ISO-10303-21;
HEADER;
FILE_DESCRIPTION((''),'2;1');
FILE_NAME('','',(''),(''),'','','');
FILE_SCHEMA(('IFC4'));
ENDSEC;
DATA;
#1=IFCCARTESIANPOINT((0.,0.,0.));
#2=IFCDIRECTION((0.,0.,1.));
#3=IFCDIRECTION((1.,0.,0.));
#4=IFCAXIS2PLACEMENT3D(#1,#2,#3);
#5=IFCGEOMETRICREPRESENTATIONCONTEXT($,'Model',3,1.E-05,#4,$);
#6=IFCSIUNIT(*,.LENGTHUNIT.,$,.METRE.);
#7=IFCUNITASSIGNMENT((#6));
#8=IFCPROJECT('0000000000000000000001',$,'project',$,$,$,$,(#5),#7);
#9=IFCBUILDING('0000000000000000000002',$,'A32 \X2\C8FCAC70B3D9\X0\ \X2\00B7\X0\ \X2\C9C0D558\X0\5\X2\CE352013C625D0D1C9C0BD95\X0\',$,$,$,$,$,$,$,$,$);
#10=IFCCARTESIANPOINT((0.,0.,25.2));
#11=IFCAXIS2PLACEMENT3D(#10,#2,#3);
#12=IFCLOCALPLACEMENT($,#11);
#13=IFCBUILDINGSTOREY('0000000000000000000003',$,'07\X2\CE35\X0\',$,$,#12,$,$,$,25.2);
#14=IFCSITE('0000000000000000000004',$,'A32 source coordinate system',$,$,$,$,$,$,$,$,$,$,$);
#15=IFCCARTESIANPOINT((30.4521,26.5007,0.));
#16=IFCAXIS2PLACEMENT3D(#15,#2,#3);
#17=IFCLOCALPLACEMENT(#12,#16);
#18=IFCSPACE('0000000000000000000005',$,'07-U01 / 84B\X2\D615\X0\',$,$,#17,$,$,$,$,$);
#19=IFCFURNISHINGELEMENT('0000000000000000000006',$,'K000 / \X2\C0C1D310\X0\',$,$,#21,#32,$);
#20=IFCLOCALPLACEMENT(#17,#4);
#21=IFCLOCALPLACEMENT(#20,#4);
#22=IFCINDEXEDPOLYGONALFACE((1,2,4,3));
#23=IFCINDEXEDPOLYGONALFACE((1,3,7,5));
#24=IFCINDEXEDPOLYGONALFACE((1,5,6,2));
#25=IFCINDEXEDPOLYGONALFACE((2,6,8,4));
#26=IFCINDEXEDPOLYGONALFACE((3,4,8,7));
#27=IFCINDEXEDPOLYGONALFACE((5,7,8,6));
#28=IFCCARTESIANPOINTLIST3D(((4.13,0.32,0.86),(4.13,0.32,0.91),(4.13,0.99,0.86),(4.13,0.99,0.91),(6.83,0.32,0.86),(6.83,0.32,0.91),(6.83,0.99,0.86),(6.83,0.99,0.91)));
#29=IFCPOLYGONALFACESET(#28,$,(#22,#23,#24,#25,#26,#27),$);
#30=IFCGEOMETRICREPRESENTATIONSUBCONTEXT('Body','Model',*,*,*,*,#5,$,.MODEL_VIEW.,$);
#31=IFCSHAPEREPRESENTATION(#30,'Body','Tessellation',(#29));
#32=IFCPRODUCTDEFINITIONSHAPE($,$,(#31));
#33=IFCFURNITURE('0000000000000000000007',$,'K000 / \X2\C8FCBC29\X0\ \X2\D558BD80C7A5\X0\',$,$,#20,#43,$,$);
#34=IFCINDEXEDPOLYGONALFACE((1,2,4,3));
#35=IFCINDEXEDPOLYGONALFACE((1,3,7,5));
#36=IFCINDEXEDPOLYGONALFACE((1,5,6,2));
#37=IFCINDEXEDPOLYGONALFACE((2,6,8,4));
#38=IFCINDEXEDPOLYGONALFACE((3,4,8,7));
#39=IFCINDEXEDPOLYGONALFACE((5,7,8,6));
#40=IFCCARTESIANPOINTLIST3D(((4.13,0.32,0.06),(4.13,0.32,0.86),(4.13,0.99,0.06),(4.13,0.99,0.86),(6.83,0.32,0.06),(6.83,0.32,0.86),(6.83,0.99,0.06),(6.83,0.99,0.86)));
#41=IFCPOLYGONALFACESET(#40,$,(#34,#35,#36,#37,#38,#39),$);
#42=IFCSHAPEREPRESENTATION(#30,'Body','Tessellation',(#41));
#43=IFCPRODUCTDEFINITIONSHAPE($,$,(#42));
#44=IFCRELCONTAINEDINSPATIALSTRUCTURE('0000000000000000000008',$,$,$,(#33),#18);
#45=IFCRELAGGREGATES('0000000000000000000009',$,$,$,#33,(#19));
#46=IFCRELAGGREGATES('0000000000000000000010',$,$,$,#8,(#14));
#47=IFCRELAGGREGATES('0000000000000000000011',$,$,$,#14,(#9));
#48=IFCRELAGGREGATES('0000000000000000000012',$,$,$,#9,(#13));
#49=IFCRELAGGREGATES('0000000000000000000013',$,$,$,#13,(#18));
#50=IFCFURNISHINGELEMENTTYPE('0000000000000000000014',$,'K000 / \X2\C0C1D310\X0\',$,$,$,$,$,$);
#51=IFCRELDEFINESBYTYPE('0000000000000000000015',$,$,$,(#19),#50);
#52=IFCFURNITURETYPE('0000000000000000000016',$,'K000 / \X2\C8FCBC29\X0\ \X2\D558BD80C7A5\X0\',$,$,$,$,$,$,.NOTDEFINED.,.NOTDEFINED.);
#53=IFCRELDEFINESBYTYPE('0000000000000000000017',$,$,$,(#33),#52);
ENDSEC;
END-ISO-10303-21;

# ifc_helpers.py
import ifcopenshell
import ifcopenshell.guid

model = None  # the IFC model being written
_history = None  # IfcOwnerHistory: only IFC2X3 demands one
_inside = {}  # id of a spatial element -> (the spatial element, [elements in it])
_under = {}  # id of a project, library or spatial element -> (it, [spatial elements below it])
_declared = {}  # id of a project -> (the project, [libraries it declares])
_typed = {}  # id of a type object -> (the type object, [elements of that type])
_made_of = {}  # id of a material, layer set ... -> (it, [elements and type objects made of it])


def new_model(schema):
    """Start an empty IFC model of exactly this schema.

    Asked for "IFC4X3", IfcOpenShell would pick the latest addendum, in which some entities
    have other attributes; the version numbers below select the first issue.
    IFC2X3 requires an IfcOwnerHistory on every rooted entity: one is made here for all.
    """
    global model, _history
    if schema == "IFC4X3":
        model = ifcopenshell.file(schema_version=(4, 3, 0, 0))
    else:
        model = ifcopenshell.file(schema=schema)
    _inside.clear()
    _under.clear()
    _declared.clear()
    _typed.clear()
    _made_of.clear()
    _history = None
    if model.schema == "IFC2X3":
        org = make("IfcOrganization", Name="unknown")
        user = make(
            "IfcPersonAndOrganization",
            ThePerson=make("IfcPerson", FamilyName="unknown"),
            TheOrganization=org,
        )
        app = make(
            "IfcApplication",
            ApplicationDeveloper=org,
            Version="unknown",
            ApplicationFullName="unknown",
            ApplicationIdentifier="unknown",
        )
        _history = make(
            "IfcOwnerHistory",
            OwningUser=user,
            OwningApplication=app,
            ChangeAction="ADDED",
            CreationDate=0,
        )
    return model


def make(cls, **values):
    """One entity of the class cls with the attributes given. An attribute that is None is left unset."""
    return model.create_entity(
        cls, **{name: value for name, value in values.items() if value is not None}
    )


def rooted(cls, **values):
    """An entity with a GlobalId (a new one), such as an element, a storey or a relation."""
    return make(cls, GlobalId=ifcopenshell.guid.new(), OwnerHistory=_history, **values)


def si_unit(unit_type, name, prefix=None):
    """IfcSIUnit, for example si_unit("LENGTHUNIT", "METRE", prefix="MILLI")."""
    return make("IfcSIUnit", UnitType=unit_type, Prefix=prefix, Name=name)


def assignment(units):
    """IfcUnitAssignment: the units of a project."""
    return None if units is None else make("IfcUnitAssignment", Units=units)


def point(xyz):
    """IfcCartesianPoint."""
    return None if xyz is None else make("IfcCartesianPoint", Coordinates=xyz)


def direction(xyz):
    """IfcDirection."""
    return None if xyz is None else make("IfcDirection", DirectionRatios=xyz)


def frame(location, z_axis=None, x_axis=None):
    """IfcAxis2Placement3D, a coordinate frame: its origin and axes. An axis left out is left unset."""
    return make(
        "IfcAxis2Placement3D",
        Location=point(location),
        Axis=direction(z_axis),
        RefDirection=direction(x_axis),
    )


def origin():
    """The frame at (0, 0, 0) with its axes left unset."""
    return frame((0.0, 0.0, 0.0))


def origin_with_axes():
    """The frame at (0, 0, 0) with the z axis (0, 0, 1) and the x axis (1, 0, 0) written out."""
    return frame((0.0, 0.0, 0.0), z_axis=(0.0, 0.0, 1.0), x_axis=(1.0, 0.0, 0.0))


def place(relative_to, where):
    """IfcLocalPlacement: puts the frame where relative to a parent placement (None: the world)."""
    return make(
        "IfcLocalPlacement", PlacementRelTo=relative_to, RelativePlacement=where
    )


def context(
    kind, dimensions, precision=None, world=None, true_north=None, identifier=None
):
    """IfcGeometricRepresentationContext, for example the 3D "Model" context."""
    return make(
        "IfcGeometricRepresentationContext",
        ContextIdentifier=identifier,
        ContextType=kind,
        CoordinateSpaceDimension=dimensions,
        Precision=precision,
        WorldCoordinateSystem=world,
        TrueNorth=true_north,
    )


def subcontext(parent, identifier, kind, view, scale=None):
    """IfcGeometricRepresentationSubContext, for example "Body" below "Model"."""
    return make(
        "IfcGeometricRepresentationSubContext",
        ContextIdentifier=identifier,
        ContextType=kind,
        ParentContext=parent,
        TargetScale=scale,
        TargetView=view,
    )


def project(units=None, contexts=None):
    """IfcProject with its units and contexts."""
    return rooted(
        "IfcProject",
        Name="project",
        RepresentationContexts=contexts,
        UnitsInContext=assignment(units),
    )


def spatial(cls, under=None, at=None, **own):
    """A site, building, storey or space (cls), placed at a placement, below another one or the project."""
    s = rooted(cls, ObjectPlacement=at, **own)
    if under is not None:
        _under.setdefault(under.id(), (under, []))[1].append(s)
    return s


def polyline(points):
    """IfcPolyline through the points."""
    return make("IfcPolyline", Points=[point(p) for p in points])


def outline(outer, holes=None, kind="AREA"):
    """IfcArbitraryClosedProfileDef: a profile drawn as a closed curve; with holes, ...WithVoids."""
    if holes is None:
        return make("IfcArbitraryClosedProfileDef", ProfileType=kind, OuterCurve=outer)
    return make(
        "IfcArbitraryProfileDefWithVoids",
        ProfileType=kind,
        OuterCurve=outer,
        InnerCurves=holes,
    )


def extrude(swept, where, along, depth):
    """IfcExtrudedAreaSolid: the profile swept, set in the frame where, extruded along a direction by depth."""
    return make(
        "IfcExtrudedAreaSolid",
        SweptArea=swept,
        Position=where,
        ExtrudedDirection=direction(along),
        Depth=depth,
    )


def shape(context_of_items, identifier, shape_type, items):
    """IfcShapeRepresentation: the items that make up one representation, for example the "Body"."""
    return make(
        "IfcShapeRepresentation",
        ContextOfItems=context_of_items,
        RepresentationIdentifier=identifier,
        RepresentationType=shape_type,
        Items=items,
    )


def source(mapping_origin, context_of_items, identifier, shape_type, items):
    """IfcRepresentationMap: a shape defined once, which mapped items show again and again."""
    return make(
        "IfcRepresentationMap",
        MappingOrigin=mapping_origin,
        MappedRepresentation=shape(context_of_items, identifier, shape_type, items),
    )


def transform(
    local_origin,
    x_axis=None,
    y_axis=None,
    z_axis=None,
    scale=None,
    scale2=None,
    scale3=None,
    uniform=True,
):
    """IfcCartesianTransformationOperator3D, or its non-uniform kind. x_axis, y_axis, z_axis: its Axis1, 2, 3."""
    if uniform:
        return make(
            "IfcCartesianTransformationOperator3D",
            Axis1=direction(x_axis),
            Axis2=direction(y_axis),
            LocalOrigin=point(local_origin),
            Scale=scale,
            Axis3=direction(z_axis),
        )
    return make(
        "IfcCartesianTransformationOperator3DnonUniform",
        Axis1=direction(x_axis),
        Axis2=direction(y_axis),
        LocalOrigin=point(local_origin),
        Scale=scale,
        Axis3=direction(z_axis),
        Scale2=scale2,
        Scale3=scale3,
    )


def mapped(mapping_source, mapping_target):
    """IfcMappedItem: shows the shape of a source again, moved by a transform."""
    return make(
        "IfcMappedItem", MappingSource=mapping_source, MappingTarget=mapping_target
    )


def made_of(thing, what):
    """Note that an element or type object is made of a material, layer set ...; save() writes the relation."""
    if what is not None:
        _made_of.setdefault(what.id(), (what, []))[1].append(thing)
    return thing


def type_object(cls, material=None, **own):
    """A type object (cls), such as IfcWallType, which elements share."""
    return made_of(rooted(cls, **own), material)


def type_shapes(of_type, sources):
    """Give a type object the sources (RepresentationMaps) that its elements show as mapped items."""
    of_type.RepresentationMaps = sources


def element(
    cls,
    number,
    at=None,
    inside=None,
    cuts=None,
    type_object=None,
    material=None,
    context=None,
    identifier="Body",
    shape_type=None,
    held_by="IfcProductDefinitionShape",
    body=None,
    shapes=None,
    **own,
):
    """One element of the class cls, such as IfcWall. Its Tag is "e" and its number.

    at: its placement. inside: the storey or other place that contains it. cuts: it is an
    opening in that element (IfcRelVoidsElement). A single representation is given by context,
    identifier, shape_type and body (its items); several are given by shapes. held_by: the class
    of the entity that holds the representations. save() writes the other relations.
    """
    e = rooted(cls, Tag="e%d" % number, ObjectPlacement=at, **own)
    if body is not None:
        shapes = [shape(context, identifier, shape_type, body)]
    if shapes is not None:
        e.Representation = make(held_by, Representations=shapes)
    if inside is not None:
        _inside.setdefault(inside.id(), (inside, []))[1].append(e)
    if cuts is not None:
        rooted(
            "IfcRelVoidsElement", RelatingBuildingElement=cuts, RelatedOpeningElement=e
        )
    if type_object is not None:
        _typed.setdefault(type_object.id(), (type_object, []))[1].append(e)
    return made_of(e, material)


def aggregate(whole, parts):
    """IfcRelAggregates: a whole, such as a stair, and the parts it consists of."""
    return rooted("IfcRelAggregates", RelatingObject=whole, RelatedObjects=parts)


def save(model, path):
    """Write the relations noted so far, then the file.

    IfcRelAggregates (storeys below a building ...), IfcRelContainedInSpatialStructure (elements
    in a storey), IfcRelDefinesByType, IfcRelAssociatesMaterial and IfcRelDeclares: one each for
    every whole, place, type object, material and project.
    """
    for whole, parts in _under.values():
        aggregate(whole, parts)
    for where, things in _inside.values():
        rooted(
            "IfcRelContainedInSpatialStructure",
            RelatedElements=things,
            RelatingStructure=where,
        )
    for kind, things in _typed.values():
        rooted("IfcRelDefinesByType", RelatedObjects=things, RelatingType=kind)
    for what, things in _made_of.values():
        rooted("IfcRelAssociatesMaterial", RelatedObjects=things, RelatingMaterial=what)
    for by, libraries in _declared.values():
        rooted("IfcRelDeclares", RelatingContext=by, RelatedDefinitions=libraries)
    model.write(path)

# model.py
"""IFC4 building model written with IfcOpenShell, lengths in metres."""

from ifc_helpers import new_model, si_unit, frame, origin, origin_with_axes, place, context, subcontext, project, spatial, polyline, outline, extrude, source, transform, mapped, type_object, type_shapes, element, aggregate, save


model = new_model("IFC4")

# Units and contexts
model_context = context("Model", 3, precision=1e-05, world=origin_with_axes())
body_context = subcontext(model_context, "Body", "Model", "MODEL_VIEW")
ifc_project = project(units=[si_unit("LENGTHUNIT", "METRE")], contexts=[model_context])

# Site, building, storey, space
site = spatial("IfcSite", under=ifc_project, Name="A32 source coordinate system")
building = spatial("IfcBuilding", under=site, Name="A32 주거동 · 지하5층–옥탑지붕")
storey_placement = place(None, frame((0.0, 0.0, 25.2), z_axis=(0.0, 0.0, 1.0), x_axis=(1.0, 0.0, 0.0)))
storey = spatial("IfcBuildingStorey", under=building, at=storey_placement, Name="07층", Elevation=25.2)
space_placement = place(storey_placement, frame((30.4521, 26.5007, 0.0), z_axis=(0.0, 0.0, 1.0), x_axis=(1.0, 0.0, 0.0)))
space = spatial("IfcSpace", under=storey, at=space_placement, Name="07-U01 / 84B형")

# Furnishing element
furnishing_element_type = type_object("IfcFurnishingElementType", Name="K000 / 상판")
shared_shape_1 = source(origin(), body_context, "Body", "SweptSolid", [
    extrude(outline(polyline([(4.13, 0.32), (4.13, 0.99), (6.83, 0.99), (6.83, 0.32), (4.13, 0.32)])), frame((0.0, 0.0, 0.86)), (0.0, 0.0, 1.0), 0.05),
])
type_shapes(furnishing_element_type, [shared_shape_1])
furniture_placement = place(space_placement, origin_with_axes())
furnishing_placement = place(furniture_placement, origin_with_axes())
furnishing = element("IfcFurnishingElement", 1, at=furnishing_placement, type_object=furnishing_element_type, Name="K000 / 상판", context=body_context, shape_type="MappedRepresentation", body=[
    mapped(shared_shape_1, transform((0.0, 0.0, 0.0), scale=1.0)),
])

# Furniture
furniture_type = type_object("IfcFurnitureType", Name="K000 / 주방 하부장", AssemblyPlace="NOTDEFINED", PredefinedType="NOTDEFINED")
shared_shape_2 = source(origin(), body_context, "Body", "SweptSolid", [
    extrude(outline(polyline([(6.83, 0.32), (4.13, 0.32), (4.13, 0.99), (6.83, 0.99), (6.83, 0.32)])), frame((0.0, 0.0, 0.06)), (0.0, 0.0, 1.0), 0.8),
])
type_shapes(furniture_type, [shared_shape_2])
furniture = element("IfcFurniture", 2, at=furniture_placement, inside=space, type_object=furniture_type, Name="K000 / 주방 하부장", context=body_context, shape_type="MappedRepresentation", body=[
    mapped(shared_shape_2, transform((0.0, 0.0, 0.0), scale=1.0)),
])
aggregate(furniture, [furnishing])

save(model, "model.ifc")
